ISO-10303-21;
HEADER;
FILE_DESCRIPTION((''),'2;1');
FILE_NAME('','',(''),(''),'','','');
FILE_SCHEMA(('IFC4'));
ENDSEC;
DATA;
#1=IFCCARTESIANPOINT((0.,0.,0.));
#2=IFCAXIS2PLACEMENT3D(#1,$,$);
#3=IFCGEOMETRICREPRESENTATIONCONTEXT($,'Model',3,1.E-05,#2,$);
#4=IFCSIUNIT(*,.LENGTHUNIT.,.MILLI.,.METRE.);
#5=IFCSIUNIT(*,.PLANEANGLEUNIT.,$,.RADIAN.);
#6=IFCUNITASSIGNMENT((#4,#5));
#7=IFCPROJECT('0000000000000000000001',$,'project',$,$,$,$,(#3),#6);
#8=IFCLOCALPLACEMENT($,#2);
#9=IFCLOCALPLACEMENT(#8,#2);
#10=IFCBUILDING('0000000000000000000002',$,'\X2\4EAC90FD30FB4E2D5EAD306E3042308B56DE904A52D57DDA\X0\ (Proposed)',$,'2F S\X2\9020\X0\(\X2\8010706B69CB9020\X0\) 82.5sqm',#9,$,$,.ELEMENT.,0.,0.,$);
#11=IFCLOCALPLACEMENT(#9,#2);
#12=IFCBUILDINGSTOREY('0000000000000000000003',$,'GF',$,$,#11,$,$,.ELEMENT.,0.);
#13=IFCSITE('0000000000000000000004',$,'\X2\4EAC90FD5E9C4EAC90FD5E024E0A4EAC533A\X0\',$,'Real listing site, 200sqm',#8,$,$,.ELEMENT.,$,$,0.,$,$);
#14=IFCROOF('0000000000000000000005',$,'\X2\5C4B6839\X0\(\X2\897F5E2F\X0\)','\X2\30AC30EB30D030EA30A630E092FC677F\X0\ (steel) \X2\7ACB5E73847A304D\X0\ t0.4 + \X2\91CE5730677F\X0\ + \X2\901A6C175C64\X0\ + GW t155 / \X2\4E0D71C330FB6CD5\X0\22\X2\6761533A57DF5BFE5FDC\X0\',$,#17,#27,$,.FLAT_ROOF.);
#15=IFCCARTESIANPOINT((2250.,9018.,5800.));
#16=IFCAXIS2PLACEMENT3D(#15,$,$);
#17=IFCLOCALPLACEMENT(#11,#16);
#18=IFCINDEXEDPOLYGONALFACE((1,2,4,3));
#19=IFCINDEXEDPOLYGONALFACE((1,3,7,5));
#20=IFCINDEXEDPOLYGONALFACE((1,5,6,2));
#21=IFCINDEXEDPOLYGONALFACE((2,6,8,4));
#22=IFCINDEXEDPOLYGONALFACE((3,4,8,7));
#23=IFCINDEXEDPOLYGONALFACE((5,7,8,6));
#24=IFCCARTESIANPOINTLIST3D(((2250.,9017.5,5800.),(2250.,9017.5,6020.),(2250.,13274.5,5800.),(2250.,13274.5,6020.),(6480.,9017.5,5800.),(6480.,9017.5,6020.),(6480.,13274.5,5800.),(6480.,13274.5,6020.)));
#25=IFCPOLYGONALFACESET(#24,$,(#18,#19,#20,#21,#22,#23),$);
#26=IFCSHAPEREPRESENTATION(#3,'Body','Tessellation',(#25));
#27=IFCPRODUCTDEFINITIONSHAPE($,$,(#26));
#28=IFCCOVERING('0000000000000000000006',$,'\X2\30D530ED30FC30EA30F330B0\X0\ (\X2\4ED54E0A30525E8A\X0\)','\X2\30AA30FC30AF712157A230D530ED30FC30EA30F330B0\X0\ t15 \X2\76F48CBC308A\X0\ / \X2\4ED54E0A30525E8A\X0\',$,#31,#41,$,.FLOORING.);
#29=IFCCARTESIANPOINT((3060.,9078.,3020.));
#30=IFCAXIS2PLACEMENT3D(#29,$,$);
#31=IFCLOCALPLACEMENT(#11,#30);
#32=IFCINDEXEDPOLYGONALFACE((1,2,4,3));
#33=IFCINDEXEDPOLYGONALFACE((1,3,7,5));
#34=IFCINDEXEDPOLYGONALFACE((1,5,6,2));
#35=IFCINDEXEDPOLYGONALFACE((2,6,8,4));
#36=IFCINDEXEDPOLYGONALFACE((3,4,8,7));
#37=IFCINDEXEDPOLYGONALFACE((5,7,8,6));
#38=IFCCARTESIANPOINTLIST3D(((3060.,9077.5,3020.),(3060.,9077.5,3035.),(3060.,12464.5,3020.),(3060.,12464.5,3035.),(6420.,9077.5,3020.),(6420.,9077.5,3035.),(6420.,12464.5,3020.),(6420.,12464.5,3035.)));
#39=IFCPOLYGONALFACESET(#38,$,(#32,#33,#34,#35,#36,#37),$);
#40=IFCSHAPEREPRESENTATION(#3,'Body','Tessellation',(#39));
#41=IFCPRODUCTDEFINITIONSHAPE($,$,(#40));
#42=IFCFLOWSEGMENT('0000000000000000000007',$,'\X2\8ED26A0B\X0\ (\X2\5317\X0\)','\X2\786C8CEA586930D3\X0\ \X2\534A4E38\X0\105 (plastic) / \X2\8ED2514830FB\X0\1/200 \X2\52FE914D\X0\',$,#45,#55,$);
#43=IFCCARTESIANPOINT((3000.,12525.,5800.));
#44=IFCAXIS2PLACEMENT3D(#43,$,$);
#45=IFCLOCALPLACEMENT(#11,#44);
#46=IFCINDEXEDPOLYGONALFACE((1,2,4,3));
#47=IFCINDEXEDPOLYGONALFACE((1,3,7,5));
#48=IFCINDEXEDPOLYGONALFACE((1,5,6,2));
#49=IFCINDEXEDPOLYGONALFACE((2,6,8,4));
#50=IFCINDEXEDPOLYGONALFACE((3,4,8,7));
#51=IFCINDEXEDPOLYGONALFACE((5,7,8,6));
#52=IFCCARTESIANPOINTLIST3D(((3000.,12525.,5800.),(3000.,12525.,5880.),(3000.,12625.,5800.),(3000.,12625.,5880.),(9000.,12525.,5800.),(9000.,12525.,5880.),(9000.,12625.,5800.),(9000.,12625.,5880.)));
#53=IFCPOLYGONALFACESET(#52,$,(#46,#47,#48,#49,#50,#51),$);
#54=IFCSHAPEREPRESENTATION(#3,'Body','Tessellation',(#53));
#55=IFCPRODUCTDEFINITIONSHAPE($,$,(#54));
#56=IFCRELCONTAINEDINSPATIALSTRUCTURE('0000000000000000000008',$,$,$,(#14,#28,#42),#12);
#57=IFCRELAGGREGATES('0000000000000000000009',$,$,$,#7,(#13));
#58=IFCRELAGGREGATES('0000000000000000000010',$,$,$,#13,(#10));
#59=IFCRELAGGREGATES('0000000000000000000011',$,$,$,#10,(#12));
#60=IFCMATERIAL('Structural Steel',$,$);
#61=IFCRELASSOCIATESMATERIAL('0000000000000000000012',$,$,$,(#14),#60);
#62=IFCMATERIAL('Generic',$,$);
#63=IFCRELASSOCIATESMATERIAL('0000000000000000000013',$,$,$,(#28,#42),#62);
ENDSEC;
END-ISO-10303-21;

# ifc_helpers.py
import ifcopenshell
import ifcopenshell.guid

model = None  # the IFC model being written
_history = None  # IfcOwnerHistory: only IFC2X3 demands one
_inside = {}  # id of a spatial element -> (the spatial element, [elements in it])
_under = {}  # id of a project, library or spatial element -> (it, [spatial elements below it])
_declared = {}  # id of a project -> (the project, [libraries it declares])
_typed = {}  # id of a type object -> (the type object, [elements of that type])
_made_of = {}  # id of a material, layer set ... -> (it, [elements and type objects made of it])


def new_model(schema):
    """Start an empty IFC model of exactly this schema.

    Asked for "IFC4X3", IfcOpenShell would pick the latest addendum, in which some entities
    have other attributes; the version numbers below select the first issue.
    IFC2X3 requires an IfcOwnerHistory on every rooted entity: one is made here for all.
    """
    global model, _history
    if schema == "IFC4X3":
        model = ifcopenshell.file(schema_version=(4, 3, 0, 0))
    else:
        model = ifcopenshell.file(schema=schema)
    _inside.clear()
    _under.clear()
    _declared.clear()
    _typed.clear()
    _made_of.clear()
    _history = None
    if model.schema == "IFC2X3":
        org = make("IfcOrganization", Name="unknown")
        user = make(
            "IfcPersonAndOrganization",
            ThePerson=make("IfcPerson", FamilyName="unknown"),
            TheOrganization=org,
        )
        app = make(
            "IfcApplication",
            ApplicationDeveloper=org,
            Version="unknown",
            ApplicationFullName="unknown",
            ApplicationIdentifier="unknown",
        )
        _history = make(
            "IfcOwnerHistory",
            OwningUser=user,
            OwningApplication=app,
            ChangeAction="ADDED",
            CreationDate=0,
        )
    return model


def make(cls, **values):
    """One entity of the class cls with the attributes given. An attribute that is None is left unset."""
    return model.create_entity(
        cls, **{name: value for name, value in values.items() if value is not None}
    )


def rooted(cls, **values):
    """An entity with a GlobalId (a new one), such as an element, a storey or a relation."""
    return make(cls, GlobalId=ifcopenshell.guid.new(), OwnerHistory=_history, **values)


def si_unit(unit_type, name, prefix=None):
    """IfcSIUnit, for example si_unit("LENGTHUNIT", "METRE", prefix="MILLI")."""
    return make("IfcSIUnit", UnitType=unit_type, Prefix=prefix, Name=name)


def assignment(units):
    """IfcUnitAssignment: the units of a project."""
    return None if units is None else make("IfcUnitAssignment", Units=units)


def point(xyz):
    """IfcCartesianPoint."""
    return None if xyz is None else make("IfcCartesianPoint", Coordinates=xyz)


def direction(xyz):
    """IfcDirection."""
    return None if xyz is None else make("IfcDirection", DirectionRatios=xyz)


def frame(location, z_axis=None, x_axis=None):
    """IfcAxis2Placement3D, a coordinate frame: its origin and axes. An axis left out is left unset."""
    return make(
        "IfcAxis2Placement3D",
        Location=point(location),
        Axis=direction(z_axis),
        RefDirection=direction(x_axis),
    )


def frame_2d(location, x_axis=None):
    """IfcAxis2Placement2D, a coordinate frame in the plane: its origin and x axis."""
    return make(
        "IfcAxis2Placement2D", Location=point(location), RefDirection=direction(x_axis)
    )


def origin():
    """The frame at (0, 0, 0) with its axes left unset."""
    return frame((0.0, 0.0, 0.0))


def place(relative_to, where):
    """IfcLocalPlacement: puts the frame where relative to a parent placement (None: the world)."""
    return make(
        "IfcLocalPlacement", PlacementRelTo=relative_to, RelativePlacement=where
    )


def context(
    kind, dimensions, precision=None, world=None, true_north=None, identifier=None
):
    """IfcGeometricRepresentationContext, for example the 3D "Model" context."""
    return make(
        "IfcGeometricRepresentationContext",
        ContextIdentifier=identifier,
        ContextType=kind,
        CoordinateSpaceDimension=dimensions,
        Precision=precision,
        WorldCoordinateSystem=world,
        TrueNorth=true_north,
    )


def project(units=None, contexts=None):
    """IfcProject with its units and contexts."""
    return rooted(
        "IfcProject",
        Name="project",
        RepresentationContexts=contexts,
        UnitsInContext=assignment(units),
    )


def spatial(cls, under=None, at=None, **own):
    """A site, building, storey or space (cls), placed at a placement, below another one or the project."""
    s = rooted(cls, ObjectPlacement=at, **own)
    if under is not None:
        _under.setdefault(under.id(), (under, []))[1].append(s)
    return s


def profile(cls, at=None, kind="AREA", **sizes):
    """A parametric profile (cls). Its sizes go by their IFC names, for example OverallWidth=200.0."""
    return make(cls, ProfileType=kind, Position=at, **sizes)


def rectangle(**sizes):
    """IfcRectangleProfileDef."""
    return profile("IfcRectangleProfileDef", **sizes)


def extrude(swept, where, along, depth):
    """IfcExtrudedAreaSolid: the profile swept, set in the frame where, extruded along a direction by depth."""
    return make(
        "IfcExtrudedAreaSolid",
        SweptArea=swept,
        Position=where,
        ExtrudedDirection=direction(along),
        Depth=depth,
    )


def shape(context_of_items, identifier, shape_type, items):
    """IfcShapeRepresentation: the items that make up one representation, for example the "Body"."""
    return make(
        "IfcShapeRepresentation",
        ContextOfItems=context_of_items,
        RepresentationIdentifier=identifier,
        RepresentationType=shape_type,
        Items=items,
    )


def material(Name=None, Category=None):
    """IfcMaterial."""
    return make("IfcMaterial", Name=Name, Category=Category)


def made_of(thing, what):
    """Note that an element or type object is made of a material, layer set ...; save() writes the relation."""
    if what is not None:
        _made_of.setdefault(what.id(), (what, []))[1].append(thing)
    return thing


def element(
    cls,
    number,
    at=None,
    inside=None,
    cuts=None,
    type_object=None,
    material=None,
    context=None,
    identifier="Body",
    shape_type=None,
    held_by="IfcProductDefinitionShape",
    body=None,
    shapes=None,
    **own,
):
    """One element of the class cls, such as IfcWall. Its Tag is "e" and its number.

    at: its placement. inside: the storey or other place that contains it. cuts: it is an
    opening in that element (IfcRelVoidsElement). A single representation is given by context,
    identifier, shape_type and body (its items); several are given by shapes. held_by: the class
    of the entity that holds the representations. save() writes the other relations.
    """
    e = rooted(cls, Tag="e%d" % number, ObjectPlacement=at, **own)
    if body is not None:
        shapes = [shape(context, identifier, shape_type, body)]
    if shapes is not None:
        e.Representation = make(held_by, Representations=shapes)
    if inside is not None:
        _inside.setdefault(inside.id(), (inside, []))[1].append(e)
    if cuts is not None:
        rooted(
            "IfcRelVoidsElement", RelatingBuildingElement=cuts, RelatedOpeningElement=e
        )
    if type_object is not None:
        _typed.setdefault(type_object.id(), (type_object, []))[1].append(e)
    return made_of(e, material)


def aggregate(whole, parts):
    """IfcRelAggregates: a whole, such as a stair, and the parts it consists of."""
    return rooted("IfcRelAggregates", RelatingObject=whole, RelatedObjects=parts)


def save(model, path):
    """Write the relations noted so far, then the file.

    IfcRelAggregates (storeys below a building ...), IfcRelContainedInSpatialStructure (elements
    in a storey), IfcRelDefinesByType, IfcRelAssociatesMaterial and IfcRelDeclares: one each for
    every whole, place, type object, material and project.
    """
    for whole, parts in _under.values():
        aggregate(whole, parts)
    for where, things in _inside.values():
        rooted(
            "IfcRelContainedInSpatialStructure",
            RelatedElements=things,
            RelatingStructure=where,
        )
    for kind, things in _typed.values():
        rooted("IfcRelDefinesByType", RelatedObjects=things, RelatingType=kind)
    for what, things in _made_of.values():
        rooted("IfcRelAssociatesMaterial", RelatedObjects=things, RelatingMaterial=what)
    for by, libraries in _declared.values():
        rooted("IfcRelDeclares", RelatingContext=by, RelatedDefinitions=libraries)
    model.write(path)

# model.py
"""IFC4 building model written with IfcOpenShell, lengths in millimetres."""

from ifc_helpers import new_model, si_unit, frame, frame_2d, origin, place, context, project, spatial, rectangle, extrude, material, element, save


model = new_model("IFC4")

# Units and contexts
model_context = context("Model", 3, precision=1e-05, world=origin())
ifc_project = project(units=[si_unit("LENGTHUNIT", "METRE", prefix="MILLI"), si_unit("PLANEANGLEUNIT", "RADIAN")], contexts=[model_context])

# Site, building, storey
site_placement = place(None, origin())
site = spatial("IfcSite", under=ifc_project, at=site_placement, Name="京都府京都市上京区", ObjectType="Real listing site, 200sqm", CompositionType="ELEMENT", RefElevation=0.0)
building_placement = place(site_placement, origin())
building = spatial("IfcBuilding", under=site, at=building_placement, Name="京都・中庭のある回遊動線 (Proposed)", ObjectType="2F S造(耐火構造) 82.5sqm", CompositionType="ELEMENT", ElevationOfRefHeight=0.0, ElevationOfTerrain=0.0)
storey_placement = place(building_placement, origin())
storey = spatial("IfcBuildingStorey", under=building, at=storey_placement, Name="GF", CompositionType="ELEMENT", Elevation=0.0)

# Roof
ifc_material_1 = material(Name="Structural Steel")
for number, where, name in (
    (1, (2250.0, 9018.0, 5800.0), "屋根(西帯)"),
):
    element("IfcRoof", number, at=place(storey_placement, frame(where)), inside=storey, material=ifc_material_1, Name=name, Description="ガルバリウム鋼板 (steel) 立平葺き t0.4 + 野地板 + 通気層 + GW t155 / 不燃・法22条区域対応", PredefinedType="FLAT_ROOF", context=model_context, shape_type="SweptSolid", body=[
        extrude(rectangle(XDim=4230.0, YDim=4257.0, at=frame_2d((2115.0, 2128.0))), frame((2250.0, 9018.0, 5800.0)), (0.0, 0.0, 1.0), 220.0),
    ])

# Covering
ifc_material_2 = material(Name="Generic")
covering_placement = place(storey_placement, frame((3060.0, 9078.0, 3020.0)))
element("IfcCovering", 2, at=covering_placement, inside=storey, material=ifc_material_2, Name="フローリング (仕上げ床)", Description="オーク無垢フローリング t15 直貼り / 仕上げ床", PredefinedType="FLOORING", context=model_context, shape_type="SweptSolid", body=[
    extrude(rectangle(XDim=3360.0, YDim=3387.0, at=frame_2d((1680.0, 1693.0))), frame((3060.0, 9078.0, 3020.0)), (0.0, 0.0, 1.0), 15.0),
])

# Flow segment
flow_segment_placement = place(storey_placement, frame((3000.0, 12525.0, 5800.0)))
element("IfcFlowSegment", 3, at=flow_segment_placement, inside=storey, material=ifc_material_2, Name="軒樋 (北)", Description="硬質塩ビ 半丸105 (plastic) / 軒先・1/200 勾配", context=model_context, shape_type="SweptSolid", body=[
    extrude(rectangle(XDim=6000.0, YDim=100.0, at=frame_2d((3000.0, 50.0))), frame((3000.0, 12525.0, 5800.0)), (0.0, 0.0, 1.0), 80.0),
])

save(model, "model.ifc")
